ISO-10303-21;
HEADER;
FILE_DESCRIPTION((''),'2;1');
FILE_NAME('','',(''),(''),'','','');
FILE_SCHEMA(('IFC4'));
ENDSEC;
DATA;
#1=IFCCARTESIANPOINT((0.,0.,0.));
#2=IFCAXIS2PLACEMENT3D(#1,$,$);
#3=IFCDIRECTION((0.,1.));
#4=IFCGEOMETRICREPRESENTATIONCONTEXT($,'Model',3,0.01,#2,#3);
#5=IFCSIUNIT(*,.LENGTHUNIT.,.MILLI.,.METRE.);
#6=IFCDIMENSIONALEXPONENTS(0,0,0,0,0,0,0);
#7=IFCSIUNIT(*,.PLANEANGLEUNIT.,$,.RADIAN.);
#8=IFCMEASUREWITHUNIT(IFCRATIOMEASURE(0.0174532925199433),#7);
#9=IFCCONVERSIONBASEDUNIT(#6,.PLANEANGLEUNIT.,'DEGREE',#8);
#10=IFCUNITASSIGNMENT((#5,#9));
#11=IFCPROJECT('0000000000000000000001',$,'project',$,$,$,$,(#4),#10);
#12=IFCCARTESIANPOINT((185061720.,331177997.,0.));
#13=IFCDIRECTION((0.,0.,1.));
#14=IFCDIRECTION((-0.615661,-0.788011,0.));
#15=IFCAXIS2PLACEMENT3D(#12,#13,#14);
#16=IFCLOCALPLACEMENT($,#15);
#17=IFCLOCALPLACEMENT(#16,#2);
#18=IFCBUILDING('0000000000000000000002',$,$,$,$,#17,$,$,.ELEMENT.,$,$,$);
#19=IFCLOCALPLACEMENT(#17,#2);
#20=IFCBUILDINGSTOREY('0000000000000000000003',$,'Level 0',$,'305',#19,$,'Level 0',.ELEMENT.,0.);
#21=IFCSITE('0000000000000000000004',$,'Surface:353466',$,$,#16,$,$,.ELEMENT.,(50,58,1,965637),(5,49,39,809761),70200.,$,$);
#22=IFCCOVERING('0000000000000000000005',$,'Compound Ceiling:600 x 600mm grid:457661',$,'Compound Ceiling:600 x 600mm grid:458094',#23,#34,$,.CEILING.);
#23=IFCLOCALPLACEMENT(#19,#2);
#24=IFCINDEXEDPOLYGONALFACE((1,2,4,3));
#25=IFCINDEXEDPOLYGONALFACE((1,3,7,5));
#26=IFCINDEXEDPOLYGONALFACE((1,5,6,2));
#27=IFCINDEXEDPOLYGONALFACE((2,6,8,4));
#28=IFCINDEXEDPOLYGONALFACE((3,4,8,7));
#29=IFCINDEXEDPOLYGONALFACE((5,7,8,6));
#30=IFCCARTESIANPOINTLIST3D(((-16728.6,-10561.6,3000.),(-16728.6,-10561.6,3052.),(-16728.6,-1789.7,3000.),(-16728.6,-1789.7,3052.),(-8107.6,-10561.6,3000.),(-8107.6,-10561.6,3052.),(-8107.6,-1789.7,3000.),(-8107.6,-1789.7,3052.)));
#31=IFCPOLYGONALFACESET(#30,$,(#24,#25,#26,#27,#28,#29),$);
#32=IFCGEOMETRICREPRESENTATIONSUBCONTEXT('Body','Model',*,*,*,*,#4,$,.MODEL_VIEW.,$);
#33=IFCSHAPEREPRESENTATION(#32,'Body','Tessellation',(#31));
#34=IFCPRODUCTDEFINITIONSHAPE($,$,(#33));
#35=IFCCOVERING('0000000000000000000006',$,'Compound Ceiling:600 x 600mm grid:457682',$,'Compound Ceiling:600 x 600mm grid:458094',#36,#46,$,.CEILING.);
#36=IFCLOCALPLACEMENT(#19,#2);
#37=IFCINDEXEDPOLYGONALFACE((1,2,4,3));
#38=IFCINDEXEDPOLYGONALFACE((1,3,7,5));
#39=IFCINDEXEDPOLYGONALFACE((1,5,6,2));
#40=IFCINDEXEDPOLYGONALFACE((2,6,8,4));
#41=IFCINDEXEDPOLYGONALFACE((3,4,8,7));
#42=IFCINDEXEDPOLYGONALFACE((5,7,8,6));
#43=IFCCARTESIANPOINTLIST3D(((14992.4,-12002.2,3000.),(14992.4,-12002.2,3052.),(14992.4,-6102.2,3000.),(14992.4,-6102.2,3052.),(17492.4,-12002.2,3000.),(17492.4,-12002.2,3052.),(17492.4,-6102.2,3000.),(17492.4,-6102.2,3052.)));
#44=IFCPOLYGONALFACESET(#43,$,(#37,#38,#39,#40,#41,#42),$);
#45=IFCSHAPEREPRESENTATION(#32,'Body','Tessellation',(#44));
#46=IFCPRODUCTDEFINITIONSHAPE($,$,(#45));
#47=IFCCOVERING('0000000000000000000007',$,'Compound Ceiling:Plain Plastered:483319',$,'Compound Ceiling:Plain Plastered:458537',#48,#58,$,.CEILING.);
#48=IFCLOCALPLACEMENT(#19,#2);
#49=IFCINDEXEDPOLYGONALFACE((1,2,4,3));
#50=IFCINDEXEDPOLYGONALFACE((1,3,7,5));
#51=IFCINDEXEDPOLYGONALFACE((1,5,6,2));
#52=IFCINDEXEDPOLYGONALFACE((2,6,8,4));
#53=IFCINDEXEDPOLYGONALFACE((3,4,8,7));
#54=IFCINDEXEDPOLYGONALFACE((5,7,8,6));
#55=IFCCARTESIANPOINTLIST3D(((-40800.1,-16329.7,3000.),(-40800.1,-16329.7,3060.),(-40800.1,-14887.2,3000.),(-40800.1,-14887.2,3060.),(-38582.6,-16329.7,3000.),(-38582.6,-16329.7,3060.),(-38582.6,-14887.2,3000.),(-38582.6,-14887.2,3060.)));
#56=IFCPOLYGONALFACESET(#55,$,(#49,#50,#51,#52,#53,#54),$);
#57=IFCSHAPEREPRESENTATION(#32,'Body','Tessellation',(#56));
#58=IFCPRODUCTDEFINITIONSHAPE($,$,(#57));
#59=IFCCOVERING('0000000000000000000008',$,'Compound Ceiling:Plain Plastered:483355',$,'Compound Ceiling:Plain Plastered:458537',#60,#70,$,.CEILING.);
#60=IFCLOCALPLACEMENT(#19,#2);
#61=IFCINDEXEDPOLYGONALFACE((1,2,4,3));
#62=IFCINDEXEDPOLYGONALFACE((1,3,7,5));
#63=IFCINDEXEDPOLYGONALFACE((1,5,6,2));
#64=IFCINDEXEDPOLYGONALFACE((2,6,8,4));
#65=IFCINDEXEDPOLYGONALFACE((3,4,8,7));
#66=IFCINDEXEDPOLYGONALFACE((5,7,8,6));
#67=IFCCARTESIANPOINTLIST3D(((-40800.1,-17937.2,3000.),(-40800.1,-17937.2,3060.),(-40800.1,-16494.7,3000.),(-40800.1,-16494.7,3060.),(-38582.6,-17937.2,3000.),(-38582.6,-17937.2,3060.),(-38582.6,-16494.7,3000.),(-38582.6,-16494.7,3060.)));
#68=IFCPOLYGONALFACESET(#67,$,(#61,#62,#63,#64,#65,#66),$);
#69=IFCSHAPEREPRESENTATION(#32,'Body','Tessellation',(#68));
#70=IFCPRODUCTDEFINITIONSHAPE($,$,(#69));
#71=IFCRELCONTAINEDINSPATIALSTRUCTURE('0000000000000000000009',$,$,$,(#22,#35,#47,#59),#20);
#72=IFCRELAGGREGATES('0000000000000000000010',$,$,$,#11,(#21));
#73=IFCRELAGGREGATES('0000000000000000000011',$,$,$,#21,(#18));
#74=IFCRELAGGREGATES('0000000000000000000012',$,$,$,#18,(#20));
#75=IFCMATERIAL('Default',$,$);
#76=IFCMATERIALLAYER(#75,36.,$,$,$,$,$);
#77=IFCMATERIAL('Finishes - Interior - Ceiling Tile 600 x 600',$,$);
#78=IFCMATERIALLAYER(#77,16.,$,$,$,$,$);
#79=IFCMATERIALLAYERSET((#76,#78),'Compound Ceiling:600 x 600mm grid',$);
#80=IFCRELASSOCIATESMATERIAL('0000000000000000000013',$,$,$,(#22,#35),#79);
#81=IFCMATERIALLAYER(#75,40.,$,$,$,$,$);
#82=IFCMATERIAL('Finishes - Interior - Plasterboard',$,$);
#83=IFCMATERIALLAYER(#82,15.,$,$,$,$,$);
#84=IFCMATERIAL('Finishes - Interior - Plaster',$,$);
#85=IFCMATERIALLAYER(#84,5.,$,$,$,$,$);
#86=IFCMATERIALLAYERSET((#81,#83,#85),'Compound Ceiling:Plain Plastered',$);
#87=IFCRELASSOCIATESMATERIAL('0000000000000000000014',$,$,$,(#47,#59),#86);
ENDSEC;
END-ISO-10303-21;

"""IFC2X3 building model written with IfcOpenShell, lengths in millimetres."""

from ifc_helpers import new_model, entity, si_unit, converted_unit, direction, frame, frame_2d, origin, origin_2d_with_axis, place, context, subcontext, project, spatial, rectangle, extrude, material, layer, layer_set, layer_usage, element, save


model = new_model("IFC2X3")

# Units and contexts
model_context = context("Model", 3, precision=0.01, world=origin(), true_north=direction((0.0, 1.0)))
body_context = subcontext(model_context, "Body", "Model", "MODEL_VIEW")
ifc_project = project(units=[si_unit("LENGTHUNIT", "METRE", prefix="MILLI"), converted_unit("PLANEANGLEUNIT", "DEGREE", entity("IfcRatioMeasure", 0.0174532925199433), si_unit("PLANEANGLEUNIT", "RADIAN"), dimensions=[0, 0, 0, 0, 0, 0, 0])], contexts=[model_context])

# Site, building, storey
site_placement = place(None, frame((185061720.0, 331177997.0, 0.0), z_axis=(0.0, 0.0, 1.0), x_axis=(-0.615661, -0.788011, 0.0)))
site = spatial("IfcSite", under=ifc_project, at=site_placement, Name="Surface:353466", CompositionType="ELEMENT", RefLatitude=(50, 58, 1, 965637), RefLongitude=(5, 49, 39, 809761), RefElevation=70200.0)
building_placement = place(site_placement, origin())
building = spatial("IfcBuilding", under=site, at=building_placement, CompositionType="ELEMENT")
storey_placement = place(building_placement, origin())
storey = spatial("IfcBuildingStorey", under=building, at=storey_placement, Name="Level 0", ObjectType="305", LongName="Level 0", CompositionType="ELEMENT", Elevation=0.0)

# Coverings
ifc_material_1 = material(Name="Default")
ifc_layer_1 = layer(ifc_material_1, 36.0)
ifc_material_2 = material(Name="Finishes - Interior - Ceiling Tile 600 x 600")
ifc_layer_2 = layer(ifc_material_2, 16.0)
ifc_layer_set_1 = layer_set([ifc_layer_1, ifc_layer_2], Name="Compound Ceiling:600 x 600mm grid")
ifc_layer_usage_1 = layer_usage(ifc_layer_set_1, "AXIS3", "POSITIVE", 0.0)
covering_1_placement = place(storey_placement, origin())
element("IfcCovering", 1, at=covering_1_placement, inside=storey, material=ifc_layer_usage_1, Name="Compound Ceiling:600 x 600mm grid:457661", ObjectType="Compound Ceiling:600 x 600mm grid:458094", PredefinedType="CEILING", context=body_context, shape_type="SweptSolid", body=[
    extrude(rectangle(XDim=8771.9, YDim=8621.0, at=frame_2d((0.0, 0.0), x_axis=(1.0, 0.0))), frame((-12418.1, -6175.7, 3000.0), z_axis=(0.0, 0.0, 1.0), x_axis=(0.0, -1.0, 0.0)), (0.0, 0.0, 1.0), 52.0),
])
ifc_layer_usage_2 = layer_usage(ifc_layer_set_1, "AXIS3", "POSITIVE", 0.0)
covering_2_placement = place(storey_placement, origin())
element("IfcCovering", 2, at=covering_2_placement, inside=storey, material=ifc_layer_usage_2, Name="Compound Ceiling:600 x 600mm grid:457682", ObjectType="Compound Ceiling:600 x 600mm grid:458094", PredefinedType="CEILING", context=body_context, shape_type="SweptSolid", body=[
    extrude(rectangle(XDim=5900.0, YDim=2500.0, at=origin_2d_with_axis()), frame((16242.4, -9052.2, 3000.0), z_axis=(0.0, 0.0, 1.0), x_axis=(0.0, -1.0, 0.0)), (0.0, 0.0, 1.0), 52.0),
])
ifc_layer_3 = layer(ifc_material_1, 40.0)
ifc_material_3 = material(Name="Finishes - Interior - Plasterboard")
ifc_layer_4 = layer(ifc_material_3, 15.0)
ifc_material_4 = material(Name="Finishes - Interior - Plaster")
ifc_layer_5 = layer(ifc_material_4, 5.0)
ifc_layer_set_2 = layer_set([ifc_layer_3, ifc_layer_4, ifc_layer_5], Name="Compound Ceiling:Plain Plastered")
ifc_layer_usage_3 = layer_usage(ifc_layer_set_2, "AXIS3", "POSITIVE", 0.0)
covering_3_placement = place(storey_placement, origin())
element("IfcCovering", 3, at=covering_3_placement, inside=storey, material=ifc_layer_usage_3, Name="Compound Ceiling:Plain Plastered:483319", ObjectType="Compound Ceiling:Plain Plastered:458537", PredefinedType="CEILING", context=body_context, shape_type="SweptSolid", body=[
    extrude(rectangle(XDim=2217.5, YDim=1442.5, at=frame_2d((0.0, 0.0), x_axis=(1.0, 0.0))), frame((-39691.3, -15608.5, 3000.0), z_axis=(0.0, 0.0, 1.0), x_axis=(-1.0, 0.0, 0.0)), (0.0, 0.0, 1.0), 60.0),
])
ifc_layer_usage_4 = layer_usage(ifc_layer_set_2, "AXIS3", "POSITIVE", 0.0)
covering_4_placement = place(storey_placement, origin())
element("IfcCovering", 4, at=covering_4_placement, inside=storey, material=ifc_layer_usage_4, Name="Compound Ceiling:Plain Plastered:483355", ObjectType="Compound Ceiling:Plain Plastered:458537", PredefinedType="CEILING", context=body_context, shape_type="SweptSolid", body=[
    extrude(rectangle(XDim=2217.5, YDim=1442.5, at=origin_2d_with_axis()), frame((-39691.3, -17216.0, 3000.0), z_axis=(0.0, 0.0, 1.0), x_axis=(-1.0, 0.0, 0.0)), (0.0, 0.0, 1.0), 60.0),
])

save(model, "model.ifc")
